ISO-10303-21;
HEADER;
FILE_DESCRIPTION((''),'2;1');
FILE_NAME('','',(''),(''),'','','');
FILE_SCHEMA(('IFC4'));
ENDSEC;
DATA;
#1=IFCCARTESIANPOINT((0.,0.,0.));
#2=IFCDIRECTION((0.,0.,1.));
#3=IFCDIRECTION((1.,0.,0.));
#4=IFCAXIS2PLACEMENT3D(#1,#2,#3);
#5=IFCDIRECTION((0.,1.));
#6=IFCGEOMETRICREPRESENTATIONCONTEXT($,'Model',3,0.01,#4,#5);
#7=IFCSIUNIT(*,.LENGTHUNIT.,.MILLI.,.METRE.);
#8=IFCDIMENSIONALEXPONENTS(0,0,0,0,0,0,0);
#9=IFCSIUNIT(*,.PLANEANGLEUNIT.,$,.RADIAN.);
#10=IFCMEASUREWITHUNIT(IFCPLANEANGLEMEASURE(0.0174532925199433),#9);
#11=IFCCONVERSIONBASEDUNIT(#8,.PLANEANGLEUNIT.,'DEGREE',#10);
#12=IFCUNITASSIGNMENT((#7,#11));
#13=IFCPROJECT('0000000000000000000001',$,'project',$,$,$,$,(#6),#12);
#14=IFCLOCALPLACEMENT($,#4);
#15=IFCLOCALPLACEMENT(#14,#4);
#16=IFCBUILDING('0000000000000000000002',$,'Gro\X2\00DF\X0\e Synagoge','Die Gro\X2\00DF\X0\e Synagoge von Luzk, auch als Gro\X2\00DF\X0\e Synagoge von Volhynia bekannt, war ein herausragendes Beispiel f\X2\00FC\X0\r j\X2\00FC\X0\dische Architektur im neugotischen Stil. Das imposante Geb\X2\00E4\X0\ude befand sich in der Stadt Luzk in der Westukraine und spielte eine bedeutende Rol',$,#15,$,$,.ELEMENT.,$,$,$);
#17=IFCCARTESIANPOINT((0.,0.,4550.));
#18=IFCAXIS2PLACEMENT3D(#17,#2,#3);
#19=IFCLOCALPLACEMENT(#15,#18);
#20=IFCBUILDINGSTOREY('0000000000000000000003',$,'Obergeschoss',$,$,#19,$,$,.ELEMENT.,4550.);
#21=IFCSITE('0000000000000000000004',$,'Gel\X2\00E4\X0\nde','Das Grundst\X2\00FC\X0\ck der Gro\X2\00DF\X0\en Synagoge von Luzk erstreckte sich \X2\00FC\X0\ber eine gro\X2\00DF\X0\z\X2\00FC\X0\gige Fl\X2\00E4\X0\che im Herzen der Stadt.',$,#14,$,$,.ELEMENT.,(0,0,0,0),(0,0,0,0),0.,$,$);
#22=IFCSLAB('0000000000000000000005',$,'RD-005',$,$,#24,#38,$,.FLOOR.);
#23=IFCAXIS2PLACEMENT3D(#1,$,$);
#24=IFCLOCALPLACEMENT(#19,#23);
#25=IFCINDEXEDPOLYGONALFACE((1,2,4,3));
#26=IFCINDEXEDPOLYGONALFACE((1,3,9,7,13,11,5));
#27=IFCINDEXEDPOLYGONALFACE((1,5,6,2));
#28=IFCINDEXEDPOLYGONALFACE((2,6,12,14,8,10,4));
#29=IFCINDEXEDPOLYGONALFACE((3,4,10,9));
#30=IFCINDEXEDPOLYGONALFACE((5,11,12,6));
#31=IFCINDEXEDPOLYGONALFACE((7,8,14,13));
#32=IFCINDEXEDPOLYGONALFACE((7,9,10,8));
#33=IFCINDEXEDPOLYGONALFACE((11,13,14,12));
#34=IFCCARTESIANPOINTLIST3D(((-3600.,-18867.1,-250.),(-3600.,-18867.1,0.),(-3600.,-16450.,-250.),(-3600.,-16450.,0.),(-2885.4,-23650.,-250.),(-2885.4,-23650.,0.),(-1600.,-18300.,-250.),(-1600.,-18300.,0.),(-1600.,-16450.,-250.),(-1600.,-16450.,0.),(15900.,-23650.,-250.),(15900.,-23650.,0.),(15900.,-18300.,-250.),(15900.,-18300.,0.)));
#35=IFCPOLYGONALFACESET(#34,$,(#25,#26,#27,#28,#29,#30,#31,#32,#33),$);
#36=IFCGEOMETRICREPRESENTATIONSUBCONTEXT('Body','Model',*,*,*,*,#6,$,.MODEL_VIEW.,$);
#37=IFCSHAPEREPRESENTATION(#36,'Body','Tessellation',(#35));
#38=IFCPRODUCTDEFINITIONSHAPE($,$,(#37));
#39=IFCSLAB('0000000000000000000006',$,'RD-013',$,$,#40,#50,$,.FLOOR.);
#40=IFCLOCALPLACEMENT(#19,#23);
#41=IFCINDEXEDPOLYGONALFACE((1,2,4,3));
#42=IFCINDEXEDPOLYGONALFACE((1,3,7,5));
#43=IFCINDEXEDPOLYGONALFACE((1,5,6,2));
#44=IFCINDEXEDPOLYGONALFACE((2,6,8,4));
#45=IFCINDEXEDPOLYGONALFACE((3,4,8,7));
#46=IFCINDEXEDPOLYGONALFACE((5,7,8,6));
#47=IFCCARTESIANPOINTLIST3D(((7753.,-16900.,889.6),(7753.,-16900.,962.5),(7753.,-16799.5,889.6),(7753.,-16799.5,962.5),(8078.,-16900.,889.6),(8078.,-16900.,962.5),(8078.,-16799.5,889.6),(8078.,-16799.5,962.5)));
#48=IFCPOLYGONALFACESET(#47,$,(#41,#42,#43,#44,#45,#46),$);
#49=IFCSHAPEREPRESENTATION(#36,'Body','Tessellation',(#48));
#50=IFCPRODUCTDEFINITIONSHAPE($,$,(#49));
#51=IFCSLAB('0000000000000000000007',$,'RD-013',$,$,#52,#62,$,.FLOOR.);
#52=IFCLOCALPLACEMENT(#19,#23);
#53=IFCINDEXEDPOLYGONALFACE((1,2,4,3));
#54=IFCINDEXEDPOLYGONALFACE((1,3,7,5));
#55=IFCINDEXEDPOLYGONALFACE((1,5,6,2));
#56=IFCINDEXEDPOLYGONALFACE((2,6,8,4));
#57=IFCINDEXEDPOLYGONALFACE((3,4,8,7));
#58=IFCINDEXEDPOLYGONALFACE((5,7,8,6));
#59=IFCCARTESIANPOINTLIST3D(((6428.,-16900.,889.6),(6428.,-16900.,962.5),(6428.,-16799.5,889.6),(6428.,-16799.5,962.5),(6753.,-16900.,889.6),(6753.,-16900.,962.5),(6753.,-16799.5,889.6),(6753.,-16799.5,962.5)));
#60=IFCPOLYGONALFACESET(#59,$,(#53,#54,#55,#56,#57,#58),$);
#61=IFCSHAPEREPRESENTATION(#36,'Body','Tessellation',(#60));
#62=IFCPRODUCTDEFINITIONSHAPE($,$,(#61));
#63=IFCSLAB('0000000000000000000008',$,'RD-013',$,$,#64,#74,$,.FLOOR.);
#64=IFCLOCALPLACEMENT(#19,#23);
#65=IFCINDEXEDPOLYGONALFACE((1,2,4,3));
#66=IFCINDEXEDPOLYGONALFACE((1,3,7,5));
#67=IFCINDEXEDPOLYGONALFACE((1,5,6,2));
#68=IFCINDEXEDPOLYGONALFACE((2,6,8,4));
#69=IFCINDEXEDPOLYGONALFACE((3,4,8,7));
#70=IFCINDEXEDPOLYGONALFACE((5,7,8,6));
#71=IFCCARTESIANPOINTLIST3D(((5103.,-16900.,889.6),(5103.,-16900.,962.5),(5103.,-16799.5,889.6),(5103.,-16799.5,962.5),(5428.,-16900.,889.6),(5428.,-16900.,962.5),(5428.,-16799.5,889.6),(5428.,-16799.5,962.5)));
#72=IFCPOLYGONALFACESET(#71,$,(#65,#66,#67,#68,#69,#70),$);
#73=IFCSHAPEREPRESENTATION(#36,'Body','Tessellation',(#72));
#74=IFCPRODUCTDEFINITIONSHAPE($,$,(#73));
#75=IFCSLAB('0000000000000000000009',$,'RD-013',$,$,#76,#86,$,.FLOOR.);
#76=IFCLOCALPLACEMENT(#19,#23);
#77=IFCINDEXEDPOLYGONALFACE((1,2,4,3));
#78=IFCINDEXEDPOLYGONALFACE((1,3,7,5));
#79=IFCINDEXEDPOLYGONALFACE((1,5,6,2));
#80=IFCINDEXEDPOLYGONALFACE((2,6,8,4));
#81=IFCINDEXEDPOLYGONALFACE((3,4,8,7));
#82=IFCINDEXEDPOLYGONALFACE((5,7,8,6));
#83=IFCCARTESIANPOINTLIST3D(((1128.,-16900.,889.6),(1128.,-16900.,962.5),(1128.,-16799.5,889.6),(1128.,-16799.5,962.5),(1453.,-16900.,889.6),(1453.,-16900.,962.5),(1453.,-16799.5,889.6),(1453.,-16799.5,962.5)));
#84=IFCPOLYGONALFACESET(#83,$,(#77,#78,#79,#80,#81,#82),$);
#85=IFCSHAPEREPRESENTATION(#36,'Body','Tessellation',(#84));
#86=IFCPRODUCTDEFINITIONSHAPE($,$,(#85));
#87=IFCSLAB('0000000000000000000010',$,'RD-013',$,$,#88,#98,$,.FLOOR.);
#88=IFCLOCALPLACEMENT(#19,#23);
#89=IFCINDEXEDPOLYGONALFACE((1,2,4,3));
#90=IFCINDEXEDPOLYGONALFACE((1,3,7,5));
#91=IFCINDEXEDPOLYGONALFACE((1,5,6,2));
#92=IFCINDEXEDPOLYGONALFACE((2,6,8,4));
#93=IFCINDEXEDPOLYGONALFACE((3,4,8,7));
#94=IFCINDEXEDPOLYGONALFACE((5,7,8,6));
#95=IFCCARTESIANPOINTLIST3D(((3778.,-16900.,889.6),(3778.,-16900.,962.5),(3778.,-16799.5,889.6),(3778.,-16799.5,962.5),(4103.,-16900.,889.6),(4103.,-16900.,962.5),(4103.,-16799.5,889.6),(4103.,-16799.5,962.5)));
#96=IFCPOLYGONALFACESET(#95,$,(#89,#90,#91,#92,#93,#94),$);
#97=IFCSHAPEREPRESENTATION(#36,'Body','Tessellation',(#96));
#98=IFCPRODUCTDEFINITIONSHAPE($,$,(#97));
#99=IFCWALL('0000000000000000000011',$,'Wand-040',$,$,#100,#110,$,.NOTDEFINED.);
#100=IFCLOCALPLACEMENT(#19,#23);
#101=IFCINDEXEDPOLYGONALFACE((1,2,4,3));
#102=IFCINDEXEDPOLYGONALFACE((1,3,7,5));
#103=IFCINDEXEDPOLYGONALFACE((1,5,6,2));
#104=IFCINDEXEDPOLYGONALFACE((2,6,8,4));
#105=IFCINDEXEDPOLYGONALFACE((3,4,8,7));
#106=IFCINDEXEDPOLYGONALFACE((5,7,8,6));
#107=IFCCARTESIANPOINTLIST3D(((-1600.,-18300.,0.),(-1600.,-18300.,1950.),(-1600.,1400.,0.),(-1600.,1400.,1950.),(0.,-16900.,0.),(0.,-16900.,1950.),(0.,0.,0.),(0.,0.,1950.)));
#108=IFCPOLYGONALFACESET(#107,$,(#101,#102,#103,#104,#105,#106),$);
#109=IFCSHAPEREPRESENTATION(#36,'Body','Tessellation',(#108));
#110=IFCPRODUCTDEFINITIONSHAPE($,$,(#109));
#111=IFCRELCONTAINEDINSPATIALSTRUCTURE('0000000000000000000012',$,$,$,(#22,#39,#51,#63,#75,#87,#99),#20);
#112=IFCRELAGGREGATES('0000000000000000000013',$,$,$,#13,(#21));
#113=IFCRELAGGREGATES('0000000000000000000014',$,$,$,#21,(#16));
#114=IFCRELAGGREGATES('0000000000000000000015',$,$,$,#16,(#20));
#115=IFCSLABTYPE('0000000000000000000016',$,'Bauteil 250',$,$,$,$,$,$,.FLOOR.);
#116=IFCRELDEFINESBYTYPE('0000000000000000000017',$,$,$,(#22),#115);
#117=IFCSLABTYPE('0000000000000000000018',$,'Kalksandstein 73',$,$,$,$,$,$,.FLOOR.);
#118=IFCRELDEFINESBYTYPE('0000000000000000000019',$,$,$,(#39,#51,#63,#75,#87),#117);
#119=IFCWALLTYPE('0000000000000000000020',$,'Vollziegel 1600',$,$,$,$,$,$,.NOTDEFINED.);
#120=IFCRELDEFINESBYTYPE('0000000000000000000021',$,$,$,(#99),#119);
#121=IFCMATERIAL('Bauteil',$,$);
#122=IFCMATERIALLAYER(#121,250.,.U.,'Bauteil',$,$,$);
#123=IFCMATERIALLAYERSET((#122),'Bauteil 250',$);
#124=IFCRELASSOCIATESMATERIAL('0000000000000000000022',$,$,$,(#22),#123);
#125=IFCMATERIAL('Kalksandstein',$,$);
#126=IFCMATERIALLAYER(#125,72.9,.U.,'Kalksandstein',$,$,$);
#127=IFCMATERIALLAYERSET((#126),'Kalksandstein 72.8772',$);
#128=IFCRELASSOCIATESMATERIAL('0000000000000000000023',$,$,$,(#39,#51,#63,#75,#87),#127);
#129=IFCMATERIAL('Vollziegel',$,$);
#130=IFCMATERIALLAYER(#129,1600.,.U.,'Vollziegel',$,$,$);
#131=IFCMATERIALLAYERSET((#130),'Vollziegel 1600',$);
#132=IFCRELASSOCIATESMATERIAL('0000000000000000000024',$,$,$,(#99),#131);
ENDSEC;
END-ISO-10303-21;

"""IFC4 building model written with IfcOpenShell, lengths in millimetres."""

from ifc_helpers import new_model, entity, si_unit, converted_unit, direction, frame, origin_with_axes, place, context, subcontext, project, spatial, line, indexed_curve, outline, extrude, material, layer, layer_set, layer_usage, type_object, element, save


model = new_model("IFC4")

# Units and contexts
model_context = context("Model", 3, precision=0.01, world=origin_with_axes(), true_north=direction((0.0, 1.0)))
body_context = subcontext(model_context, "Body", "Model", "MODEL_VIEW")
ifc_project = project(units=[si_unit("LENGTHUNIT", "METRE", prefix="MILLI"), converted_unit("PLANEANGLEUNIT", "DEGREE", entity("IfcPlaneAngleMeasure", 0.0174532925199433), si_unit("PLANEANGLEUNIT", "RADIAN"), dimensions=[0, 0, 0, 0, 0, 0, 0])], contexts=[model_context])

# Site, building, storey
site_placement = place(None, origin_with_axes())
site = spatial("IfcSite", under=ifc_project, at=site_placement, Name="Gelände", Description="Das Grundstück der Großen Synagoge von Luzk erstreckte sich über eine großzügige Fläche im Herzen der Stadt.", CompositionType="ELEMENT", RefLatitude=(0, 0, 0, 0), RefLongitude=(0, 0, 0, 0), RefElevation=0.0)
building_placement = place(site_placement, origin_with_axes())
building = spatial("IfcBuilding", under=site, at=building_placement, Name="Große Synagoge", Description="Die Große Synagoge von Luzk, auch als Große Synagoge von Volhynia bekannt, war ein herausragendes Beispiel für jüdische Architektur im neugotischen Stil. Das imposante Gebäude befand sich in der Stadt Luzk in der Westukraine und spielte eine bedeutende Rol", CompositionType="ELEMENT")
storey_placement = place(building_placement, frame((0.0, 0.0, 4550.0), z_axis=(0.0, 0.0, 1.0), x_axis=(1.0, 0.0, 0.0)))
storey = spatial("IfcBuildingStorey", under=building, at=storey_placement, Name="Obergeschoss", CompositionType="ELEMENT", Elevation=4550.0)

# Shared definitions
ifc_material_1 = material(Name="Kalksandstein")

# Slabs
ifc_material_2 = material(Name="Bauteil")
ifc_layer_1 = layer(ifc_material_2, 250.0, ventilated="UNKNOWN", Name="Bauteil")
ifc_layer_set_1 = layer_set([ifc_layer_1], Name="Bauteil 250")
ifc_layer_usage_1 = layer_usage(ifc_layer_set_1, "AXIS3", "NEGATIVE", 250.0)
slab_type_1 = type_object("IfcSlabType", Name="Bauteil 250", PredefinedType="FLOOR")
slab_1_placement = place(storey_placement, frame((-1600.0, -16450.0, 0.0), z_axis=(0.0, 0.0, 1.0), x_axis=(1.0, 0.0, 0.0)))
element("IfcSlab", 1, at=slab_1_placement, inside=storey, type_object=slab_type_1, material=ifc_layer_usage_1, Name="RD-005", PredefinedType="FLOOR", context=body_context, shape_type="SweptSolid", body=[
    extrude(outline(indexed_curve([(0.0, 0.0), (-2000.0, 0.0), (-2000.0, -2417.1), (-1285.4, -7200.0), (17500.0, -7200.0), (17500.0, -1850.0), (0.0, -1850.0)], segments=[line(1, 2, 3, 4, 5, 6, 7, 1)])), frame((0.0, 0.0, -250.0), z_axis=(0.0, 0.0, 1.0), x_axis=(1.0, 0.0, 0.0)), (0.0, 0.0, 1.0), 250.0),
])
ifc_layer_2 = layer(ifc_material_1, 72.9, ventilated="UNKNOWN", Name="Kalksandstein")
ifc_layer_set_2 = layer_set([ifc_layer_2], Name="Kalksandstein 72.8772")
ifc_layer_usage_2 = layer_usage(ifc_layer_set_2, "AXIS3", "NEGATIVE", 72.9)
slab_type_2 = type_object("IfcSlabType", Name="Kalksandstein 73", PredefinedType="FLOOR")
slab_2_placement = place(storey_placement, frame((7753.0, -16900.0, 962.5), z_axis=(0.0, 0.0, 1.0), x_axis=(1.0, 0.0, 0.0)))
element("IfcSlab", 2, at=slab_2_placement, inside=storey, type_object=slab_type_2, material=ifc_layer_usage_2, Name="RD-013", PredefinedType="FLOOR", context=body_context, shape_type="SweptSolid", body=[
    extrude(outline(indexed_curve([(0.0, 0.0), (325.0, 0.0), (325.0, 100.5), (0.0, 100.5)], segments=[line(1, 2, 3, 4, 1)])), frame((0.0, 0.0, -72.9), z_axis=(0.0, 0.0, 1.0), x_axis=(1.0, 0.0, 0.0)), (0.0, 0.0, 1.0), 72.9),
])
ifc_layer_usage_3 = layer_usage(ifc_layer_set_2, "AXIS3", "NEGATIVE", 72.9)
slab_3_placement = place(storey_placement, frame((6428.0, -16900.0, 962.5), z_axis=(0.0, 0.0, 1.0), x_axis=(1.0, 0.0, 0.0)))
element("IfcSlab", 3, at=slab_3_placement, inside=storey, type_object=slab_type_2, material=ifc_layer_usage_3, Name="RD-013", PredefinedType="FLOOR", context=body_context, shape_type="SweptSolid", body=[
    extrude(outline(indexed_curve([(0.0, 0.0), (325.0, 0.0), (325.0, 100.5), (0.0, 100.5)], segments=[line(1, 2, 3, 4, 1)])), frame((0.0, 0.0, -72.9), z_axis=(0.0, 0.0, 1.0), x_axis=(1.0, 0.0, 0.0)), (0.0, 0.0, 1.0), 72.9),
])
ifc_layer_usage_4 = layer_usage(ifc_layer_set_2, "AXIS3", "NEGATIVE", 72.9)
slab_4_placement = place(storey_placement, frame((5103.0, -16900.0, 962.5), z_axis=(0.0, 0.0, 1.0), x_axis=(1.0, 0.0, 0.0)))
element("IfcSlab", 4, at=slab_4_placement, inside=storey, type_object=slab_type_2, material=ifc_layer_usage_4, Name="RD-013", PredefinedType="FLOOR", context=body_context, shape_type="SweptSolid", body=[
    extrude(outline(indexed_curve([(0.0, 0.0), (325.0, 0.0), (325.0, 100.5), (0.0, 100.5)], segments=[line(1, 2, 3, 4, 1)])), frame((0.0, 0.0, -72.9), z_axis=(0.0, 0.0, 1.0), x_axis=(1.0, 0.0, 0.0)), (0.0, 0.0, 1.0), 72.9),
])
ifc_layer_usage_5 = layer_usage(ifc_layer_set_2, "AXIS3", "NEGATIVE", 72.9)
slab_5_placement = place(storey_placement, frame((1128.0, -16900.0, 962.5), z_axis=(0.0, 0.0, 1.0), x_axis=(1.0, 0.0, 0.0)))
element("IfcSlab", 5, at=slab_5_placement, inside=storey, type_object=slab_type_2, material=ifc_layer_usage_5, Name="RD-013", PredefinedType="FLOOR", context=body_context, shape_type="SweptSolid", body=[
    extrude(outline(indexed_curve([(0.0, 0.0), (325.0, 0.0), (325.0, 100.5), (0.0, 100.5)], segments=[line(1, 2, 3, 4, 1)])), frame((0.0, 0.0, -72.9), z_axis=(0.0, 0.0, 1.0), x_axis=(1.0, 0.0, 0.0)), (0.0, 0.0, 1.0), 72.9),
])
ifc_layer_usage_6 = layer_usage(ifc_layer_set_2, "AXIS3", "NEGATIVE", 72.9)
slab_6_placement = place(storey_placement, frame((3778.0, -16900.0, 962.5), z_axis=(0.0, 0.0, 1.0), x_axis=(1.0, 0.0, 0.0)))
element("IfcSlab", 6, at=slab_6_placement, inside=storey, type_object=slab_type_2, material=ifc_layer_usage_6, Name="RD-013", PredefinedType="FLOOR", context=body_context, shape_type="SweptSolid", body=[
    extrude(outline(indexed_curve([(0.0, 0.0), (325.0, 0.0), (325.0, 100.5), (0.0, 100.5)], segments=[line(1, 2, 3, 4, 1)])), frame((0.0, 0.0, -72.9), z_axis=(0.0, 0.0, 1.0), x_axis=(1.0, 0.0, 0.0)), (0.0, 0.0, 1.0), 72.9),
])

# Wall
ifc_material_3 = material(Name="Vollziegel")
ifc_layer_3 = layer(ifc_material_3, 1600.0, ventilated="UNKNOWN", Name="Vollziegel")
ifc_layer_set_3 = layer_set([ifc_layer_3], Name="Vollziegel 1600")
ifc_layer_usage_7 = layer_usage(ifc_layer_set_3, "AXIS2", "POSITIVE", -1600.0)
wall_type_1 = type_object("IfcWallType", Name="Vollziegel 1600", PredefinedType="NOTDEFINED")
wall_1_placement = place(storey_placement, frame((-1600.0, -18300.0, 0.0), z_axis=(0.0, 0.0, 1.0), x_axis=(0.0, 1.0, 0.0)))
element("IfcWall", 7, at=wall_1_placement, inside=storey, type_object=wall_type_1, material=ifc_layer_usage_7, Name="Wand-040", PredefinedType="NOTDEFINED", context=body_context, shape_type="SweptSolid", body=[
    extrude(outline(indexed_curve([(1400.0, -1600.0), (18300.0, -1600.0), (19700.0, 0.0), (0.0, 0.0)], segments=[line(1, 2, 3, 4, 1)])), origin_with_axes(), (0.0, 0.0, 1.0), 1950.0),
])

save(model, "model.ifc")
